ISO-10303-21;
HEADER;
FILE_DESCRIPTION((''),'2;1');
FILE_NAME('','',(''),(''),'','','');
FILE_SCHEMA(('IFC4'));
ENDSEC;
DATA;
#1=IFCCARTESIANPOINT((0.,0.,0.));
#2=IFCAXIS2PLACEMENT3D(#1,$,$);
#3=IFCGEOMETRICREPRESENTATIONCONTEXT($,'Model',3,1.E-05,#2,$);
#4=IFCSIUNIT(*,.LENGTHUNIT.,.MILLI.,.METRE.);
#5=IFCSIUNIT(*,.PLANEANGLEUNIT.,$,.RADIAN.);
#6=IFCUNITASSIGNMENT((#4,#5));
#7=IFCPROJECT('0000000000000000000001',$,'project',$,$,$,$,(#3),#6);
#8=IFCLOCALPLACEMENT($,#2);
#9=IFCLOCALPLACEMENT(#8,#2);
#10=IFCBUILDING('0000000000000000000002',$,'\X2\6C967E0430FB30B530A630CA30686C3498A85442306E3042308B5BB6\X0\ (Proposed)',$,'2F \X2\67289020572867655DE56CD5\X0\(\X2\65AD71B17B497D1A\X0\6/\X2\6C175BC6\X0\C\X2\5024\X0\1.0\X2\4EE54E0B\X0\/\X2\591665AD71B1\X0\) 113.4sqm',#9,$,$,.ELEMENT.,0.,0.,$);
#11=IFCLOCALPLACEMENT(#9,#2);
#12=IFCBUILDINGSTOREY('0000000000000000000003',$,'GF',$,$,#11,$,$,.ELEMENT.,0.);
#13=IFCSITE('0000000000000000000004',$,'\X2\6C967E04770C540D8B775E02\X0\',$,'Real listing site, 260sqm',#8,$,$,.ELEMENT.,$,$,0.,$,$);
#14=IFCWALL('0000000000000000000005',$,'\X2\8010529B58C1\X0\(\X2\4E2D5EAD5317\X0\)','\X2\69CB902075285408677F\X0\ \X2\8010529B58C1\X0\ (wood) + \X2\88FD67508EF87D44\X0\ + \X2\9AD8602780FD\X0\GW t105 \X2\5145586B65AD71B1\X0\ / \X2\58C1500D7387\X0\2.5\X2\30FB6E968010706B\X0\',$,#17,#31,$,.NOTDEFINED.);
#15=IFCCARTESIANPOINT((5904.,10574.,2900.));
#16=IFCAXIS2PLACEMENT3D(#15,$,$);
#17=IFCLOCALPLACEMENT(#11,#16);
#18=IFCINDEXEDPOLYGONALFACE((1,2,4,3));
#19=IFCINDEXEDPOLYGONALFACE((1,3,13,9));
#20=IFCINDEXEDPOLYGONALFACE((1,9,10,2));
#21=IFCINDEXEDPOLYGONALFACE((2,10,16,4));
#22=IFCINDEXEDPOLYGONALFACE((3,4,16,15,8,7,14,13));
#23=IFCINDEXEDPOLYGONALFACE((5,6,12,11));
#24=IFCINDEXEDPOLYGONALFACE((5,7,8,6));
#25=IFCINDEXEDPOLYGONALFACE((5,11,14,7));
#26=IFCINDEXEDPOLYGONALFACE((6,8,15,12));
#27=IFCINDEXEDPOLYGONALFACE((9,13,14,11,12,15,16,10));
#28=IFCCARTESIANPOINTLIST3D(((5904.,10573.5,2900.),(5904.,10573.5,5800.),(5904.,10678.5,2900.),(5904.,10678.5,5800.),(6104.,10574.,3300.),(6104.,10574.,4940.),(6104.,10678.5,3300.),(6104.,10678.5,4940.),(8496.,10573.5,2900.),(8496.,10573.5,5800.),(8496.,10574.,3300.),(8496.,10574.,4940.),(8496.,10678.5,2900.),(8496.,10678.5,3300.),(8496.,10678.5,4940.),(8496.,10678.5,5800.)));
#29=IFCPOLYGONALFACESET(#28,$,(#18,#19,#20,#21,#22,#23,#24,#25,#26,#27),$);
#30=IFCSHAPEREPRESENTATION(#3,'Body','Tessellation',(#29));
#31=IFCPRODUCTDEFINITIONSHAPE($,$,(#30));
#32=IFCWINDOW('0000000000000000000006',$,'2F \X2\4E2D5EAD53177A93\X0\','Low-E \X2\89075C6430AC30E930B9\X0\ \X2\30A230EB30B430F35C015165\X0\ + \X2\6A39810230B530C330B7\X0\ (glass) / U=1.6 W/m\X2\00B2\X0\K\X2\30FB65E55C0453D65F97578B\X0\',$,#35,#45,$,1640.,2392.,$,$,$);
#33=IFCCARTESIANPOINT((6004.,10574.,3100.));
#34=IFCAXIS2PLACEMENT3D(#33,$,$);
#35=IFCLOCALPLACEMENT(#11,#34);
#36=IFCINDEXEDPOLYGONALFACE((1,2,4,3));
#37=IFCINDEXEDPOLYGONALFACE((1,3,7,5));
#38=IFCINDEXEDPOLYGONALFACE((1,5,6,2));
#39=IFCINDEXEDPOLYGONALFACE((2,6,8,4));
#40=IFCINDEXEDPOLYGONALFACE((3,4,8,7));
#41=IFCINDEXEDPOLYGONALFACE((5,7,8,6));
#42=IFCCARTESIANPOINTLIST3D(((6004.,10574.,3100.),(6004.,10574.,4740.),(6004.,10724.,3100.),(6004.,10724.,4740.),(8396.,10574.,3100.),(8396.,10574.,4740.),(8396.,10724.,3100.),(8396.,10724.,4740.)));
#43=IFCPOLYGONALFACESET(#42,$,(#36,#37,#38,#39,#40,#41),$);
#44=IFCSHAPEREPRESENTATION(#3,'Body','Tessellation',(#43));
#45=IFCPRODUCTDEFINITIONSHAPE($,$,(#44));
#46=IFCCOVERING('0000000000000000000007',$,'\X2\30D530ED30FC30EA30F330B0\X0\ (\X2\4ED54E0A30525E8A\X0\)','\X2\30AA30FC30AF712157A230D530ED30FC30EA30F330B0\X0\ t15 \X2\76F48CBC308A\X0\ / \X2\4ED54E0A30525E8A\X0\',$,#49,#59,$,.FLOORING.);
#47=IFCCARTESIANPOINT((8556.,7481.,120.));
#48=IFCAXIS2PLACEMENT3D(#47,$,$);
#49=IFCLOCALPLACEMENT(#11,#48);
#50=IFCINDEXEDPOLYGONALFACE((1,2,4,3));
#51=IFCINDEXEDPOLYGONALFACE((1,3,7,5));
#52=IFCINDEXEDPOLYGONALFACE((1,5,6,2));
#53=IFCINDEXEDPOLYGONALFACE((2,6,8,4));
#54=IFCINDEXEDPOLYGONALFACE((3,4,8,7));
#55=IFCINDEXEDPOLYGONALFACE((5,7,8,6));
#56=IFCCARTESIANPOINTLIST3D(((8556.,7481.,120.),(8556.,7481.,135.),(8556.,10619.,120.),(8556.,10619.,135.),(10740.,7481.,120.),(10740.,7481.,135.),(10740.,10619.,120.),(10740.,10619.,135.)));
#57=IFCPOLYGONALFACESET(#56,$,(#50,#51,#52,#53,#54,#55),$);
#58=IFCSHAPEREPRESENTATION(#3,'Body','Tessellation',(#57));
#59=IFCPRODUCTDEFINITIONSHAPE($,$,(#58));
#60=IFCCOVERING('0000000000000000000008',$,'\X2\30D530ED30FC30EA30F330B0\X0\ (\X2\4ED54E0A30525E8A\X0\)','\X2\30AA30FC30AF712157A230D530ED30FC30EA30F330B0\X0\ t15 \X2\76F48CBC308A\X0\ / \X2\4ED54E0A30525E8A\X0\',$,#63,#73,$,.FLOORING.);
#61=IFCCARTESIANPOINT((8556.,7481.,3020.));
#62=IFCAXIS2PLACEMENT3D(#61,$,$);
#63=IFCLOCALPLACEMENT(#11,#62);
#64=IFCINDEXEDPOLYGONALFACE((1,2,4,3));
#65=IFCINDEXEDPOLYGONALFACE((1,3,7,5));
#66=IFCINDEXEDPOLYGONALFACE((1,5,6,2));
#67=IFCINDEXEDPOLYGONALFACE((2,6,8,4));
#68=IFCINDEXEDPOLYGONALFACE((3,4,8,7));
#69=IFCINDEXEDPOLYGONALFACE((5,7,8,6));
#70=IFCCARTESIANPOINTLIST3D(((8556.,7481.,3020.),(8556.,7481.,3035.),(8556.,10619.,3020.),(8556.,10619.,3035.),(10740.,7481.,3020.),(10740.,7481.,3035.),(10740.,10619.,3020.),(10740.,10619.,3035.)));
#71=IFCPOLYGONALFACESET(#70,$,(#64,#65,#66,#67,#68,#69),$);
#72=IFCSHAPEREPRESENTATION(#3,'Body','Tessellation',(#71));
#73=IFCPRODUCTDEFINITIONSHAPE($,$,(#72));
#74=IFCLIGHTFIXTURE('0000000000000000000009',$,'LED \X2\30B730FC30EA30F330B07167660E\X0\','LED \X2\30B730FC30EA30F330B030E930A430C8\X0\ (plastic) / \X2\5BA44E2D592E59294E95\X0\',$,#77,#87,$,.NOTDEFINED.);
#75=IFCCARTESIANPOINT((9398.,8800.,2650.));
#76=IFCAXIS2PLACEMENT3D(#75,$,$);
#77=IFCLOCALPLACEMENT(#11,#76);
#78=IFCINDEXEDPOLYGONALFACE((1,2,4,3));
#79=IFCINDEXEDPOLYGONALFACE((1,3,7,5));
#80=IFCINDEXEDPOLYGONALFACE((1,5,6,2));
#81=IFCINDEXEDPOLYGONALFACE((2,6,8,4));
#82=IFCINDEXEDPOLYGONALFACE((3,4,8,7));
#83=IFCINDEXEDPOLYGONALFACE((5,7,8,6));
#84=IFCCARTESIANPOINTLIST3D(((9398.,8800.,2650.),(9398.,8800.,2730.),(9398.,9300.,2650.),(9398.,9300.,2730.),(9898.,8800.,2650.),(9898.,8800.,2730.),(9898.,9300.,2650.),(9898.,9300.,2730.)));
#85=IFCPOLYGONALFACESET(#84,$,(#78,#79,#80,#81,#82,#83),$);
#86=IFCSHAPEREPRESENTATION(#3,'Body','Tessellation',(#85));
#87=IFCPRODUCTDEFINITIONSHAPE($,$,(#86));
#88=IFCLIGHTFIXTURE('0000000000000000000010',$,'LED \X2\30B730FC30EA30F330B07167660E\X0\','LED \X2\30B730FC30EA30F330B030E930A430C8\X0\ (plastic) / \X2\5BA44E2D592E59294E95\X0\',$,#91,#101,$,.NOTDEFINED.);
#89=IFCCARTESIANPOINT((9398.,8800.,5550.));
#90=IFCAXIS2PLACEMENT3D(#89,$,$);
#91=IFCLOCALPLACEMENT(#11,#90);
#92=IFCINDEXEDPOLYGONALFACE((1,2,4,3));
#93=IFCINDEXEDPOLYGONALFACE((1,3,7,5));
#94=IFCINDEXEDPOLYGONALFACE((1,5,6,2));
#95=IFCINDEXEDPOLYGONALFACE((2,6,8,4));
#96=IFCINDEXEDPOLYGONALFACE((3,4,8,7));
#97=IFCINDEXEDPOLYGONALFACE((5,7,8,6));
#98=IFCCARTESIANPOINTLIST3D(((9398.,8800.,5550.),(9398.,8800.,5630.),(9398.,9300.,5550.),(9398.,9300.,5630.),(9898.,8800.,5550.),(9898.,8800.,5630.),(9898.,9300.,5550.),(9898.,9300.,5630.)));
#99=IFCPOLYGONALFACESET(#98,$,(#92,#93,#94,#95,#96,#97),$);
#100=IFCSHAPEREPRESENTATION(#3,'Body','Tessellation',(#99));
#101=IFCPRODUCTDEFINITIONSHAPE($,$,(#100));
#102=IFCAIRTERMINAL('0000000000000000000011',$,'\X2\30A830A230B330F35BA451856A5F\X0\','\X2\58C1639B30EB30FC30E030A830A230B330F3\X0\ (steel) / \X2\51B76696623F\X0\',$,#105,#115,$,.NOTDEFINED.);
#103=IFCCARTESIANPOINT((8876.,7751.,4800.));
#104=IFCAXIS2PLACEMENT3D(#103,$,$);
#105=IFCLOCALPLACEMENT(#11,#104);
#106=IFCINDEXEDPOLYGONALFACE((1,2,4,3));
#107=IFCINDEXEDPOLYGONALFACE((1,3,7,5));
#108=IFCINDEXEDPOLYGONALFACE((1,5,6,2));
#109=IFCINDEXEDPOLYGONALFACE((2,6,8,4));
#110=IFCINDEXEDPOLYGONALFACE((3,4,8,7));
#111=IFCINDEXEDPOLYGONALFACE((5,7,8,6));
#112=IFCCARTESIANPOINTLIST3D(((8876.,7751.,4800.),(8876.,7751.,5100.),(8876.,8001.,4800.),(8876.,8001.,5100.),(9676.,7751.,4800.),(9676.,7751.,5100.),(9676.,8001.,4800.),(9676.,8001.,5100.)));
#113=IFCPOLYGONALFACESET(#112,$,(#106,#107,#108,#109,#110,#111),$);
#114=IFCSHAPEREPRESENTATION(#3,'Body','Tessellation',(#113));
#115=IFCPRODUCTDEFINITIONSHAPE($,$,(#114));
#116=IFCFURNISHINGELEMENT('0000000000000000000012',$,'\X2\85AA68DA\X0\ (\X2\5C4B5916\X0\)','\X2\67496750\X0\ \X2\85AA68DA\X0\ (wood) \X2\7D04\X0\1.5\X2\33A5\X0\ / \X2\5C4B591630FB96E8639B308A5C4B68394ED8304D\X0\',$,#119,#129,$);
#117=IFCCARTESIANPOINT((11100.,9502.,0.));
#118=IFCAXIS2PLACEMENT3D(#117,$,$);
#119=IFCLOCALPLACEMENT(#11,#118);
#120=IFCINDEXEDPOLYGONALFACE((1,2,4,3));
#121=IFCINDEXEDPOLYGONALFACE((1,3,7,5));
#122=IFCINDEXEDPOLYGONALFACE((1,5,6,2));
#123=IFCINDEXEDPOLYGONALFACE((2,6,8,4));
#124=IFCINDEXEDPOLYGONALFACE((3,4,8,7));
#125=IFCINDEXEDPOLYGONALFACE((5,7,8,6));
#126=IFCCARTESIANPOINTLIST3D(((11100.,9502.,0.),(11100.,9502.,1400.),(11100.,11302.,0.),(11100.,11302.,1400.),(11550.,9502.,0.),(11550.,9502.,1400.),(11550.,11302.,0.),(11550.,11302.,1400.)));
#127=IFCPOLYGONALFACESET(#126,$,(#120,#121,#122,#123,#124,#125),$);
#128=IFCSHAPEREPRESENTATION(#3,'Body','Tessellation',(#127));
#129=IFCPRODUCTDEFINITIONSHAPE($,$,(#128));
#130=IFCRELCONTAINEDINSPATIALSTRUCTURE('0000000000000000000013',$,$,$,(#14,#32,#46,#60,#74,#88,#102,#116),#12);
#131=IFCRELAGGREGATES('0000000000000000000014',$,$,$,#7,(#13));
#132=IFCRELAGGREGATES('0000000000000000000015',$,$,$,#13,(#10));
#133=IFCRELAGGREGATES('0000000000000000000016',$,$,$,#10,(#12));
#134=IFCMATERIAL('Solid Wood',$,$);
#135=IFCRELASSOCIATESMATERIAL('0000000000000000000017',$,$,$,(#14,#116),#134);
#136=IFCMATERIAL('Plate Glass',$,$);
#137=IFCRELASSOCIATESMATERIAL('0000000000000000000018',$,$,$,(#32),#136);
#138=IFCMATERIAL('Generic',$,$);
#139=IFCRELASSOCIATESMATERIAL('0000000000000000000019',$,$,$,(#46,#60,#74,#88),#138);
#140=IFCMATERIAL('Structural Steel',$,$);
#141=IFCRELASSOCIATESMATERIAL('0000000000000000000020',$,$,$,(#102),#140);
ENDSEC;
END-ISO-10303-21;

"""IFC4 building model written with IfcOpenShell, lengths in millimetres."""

from ifc_helpers import new_model, si_unit, frame, frame_2d, origin, place, context, project, spatial, rectangle, extrude, material, element, fill, save


model = new_model("IFC4")

# Units and contexts
model_context = context("Model", 3, precision=1e-05, world=origin())
ifc_project = project(units=[si_unit("LENGTHUNIT", "METRE", prefix="MILLI"), si_unit("PLANEANGLEUNIT", "RADIAN")], contexts=[model_context])

# Site, building, storey
site_placement = place(None, origin())
site = spatial("IfcSite", under=ifc_project, at=site_placement, Name="沖縄県名護市", ObjectType="Real listing site, 260sqm", CompositionType="ELEMENT", RefElevation=0.0)
building_placement = place(site_placement, origin())
building = spatial("IfcBuilding", under=site, at=building_placement, Name="沖縄・サウナと水風呂のある家 (Proposed)", ObjectType="2F 木造在来工法(断熱等級6/気密C値1.0以下/外断熱) 113.4sqm", CompositionType="ELEMENT", ElevationOfRefHeight=0.0, ElevationOfTerrain=0.0)
storey_placement = place(building_placement, origin())
storey = spatial("IfcBuildingStorey", under=building, at=storey_placement, Name="GF", CompositionType="ELEMENT", Elevation=0.0)

# Shared definitions
ifc_material_1 = material(Name="Solid Wood")

# Wall, opening, window
ifc_material_2 = material(Name="Plate Glass")
wall_1_placement = place(storey_placement, frame((5904.0, 10574.0, 2900.0)))
wall_1 = element("IfcWall", 1, at=wall_1_placement, inside=storey, material=ifc_material_1, Name="耐力壁(中庭北)", Description="構造用合板 耐力壁 (wood) + 製材軸組 + 高性能GW t105 充填断熱 / 壁倍率2.5・準耐火", PredefinedType="NOTDEFINED", context=model_context, shape_type="SweptSolid", body=[
    extrude(rectangle(XDim=2592.0, YDim=105.0, at=frame_2d((1296.0, 52.0))), frame((5904.0, 10574.0, 2900.0)), (0.0, 0.0, 1.0), 2900.0),
])
opening_1_placement = place(storey_placement, frame((6004.0, 10574.0, 3100.0)))
opening_1 = element("IfcOpeningElement", 2, at=opening_1_placement, cuts=wall_1, PredefinedType="NOTDEFINED", context=model_context, shape_type="SweptSolid", body=[
    extrude(rectangle(XDim=2392.0, YDim=150.0, at=frame_2d((1196.0, 75.0))), frame((6004.0, 10574.0, 3100.0)), (0.0, 0.0, 1.0), 1640.0),
])
window_1_placement = place(storey_placement, frame((6004.0, 10574.0, 3100.0)))
window_1 = element("IfcWindow", 3, at=window_1_placement, inside=storey, material=ifc_material_2, Name="2F 中庭北窓", Description="Low-E 複層ガラス アルゴン封入 + 樹脂サッシ (glass) / U=1.6 W/m²K・日射取得型", OverallHeight=1640.0, OverallWidth=2392.0, context=model_context, shape_type="SweptSolid", body=[
    extrude(rectangle(XDim=2392.0, YDim=150.0, at=frame_2d((1196.0, 75.0))), frame((6004.0, 10574.0, 3100.0)), (0.0, 0.0, 1.0), 1640.0),
])
fill(opening_1, window_1)

# Coverings
ifc_material_3 = material(Name="Generic")
covering_1_placement = place(storey_placement, frame((8556.0, 7481.0, 120.0)))
element("IfcCovering", 4, at=covering_1_placement, inside=storey, material=ifc_material_3, Name="フローリング (仕上げ床)", Description="オーク無垢フローリング t15 直貼り / 仕上げ床", PredefinedType="FLOORING", context=model_context, shape_type="SweptSolid", body=[
    extrude(rectangle(XDim=2184.0, YDim=3138.0, at=frame_2d((1092.0, 1569.0))), frame((8556.0, 7481.0, 120.0)), (0.0, 0.0, 1.0), 15.0),
])
covering_2_placement = place(storey_placement, frame((8556.0, 7481.0, 3020.0)))
element("IfcCovering", 5, at=covering_2_placement, inside=storey, material=ifc_material_3, Name="フローリング (仕上げ床)", Description="オーク無垢フローリング t15 直貼り / 仕上げ床", PredefinedType="FLOORING", context=model_context, shape_type="SweptSolid", body=[
    extrude(rectangle(XDim=2184.0, YDim=3138.0, at=frame_2d((1092.0, 1569.0))), frame((8556.0, 7481.0, 3020.0)), (0.0, 0.0, 1.0), 15.0),
])

# Light fixtures
light_fixture_1_placement = place(storey_placement, frame((9398.0, 8800.0, 2650.0)))
element("IfcLightFixture", 6, at=light_fixture_1_placement, inside=storey, material=ifc_material_3, Name="LED シーリング照明", Description="LED シーリングライト (plastic) / 室中央天井", PredefinedType="NOTDEFINED", context=model_context, shape_type="SweptSolid", body=[
    extrude(rectangle(XDim=500.0, YDim=500.0, at=frame_2d((250.0, 250.0))), frame((9398.0, 8800.0, 2650.0)), (0.0, 0.0, 1.0), 80.0),
])
light_fixture_2_placement = place(storey_placement, frame((9398.0, 8800.0, 5550.0)))
element("IfcLightFixture", 7, at=light_fixture_2_placement, inside=storey, material=ifc_material_3, Name="LED シーリング照明", Description="LED シーリングライト (plastic) / 室中央天井", PredefinedType="NOTDEFINED", context=model_context, shape_type="SweptSolid", body=[
    extrude(rectangle(XDim=500.0, YDim=500.0, at=frame_2d((250.0, 250.0))), frame((9398.0, 8800.0, 5550.0)), (0.0, 0.0, 1.0), 80.0),
])

# Air terminal
ifc_material_4 = material(Name="Structural Steel")
air_terminal_placement = place(storey_placement, frame((8876.0, 7751.0, 4800.0)))
element("IfcAirTerminal", 8, at=air_terminal_placement, inside=storey, material=ifc_material_4, Name="エアコン室内機", Description="壁掛ルームエアコン (steel) / 冷暖房", PredefinedType="NOTDEFINED", context=model_context, shape_type="SweptSolid", body=[
    extrude(rectangle(XDim=800.0, YDim=250.0, at=frame_2d((400.0, 125.0))), frame((8876.0, 7751.0, 4800.0)), (0.0, 0.0, 1.0), 300.0),
])

# Furnishing element
furnishing_placement = place(storey_placement, frame((11100.0, 9502.0, 0.0)))
element("IfcFurnishingElement", 9, at=furnishing_placement, inside=storey, material=ifc_material_1, Name="薪棚 (屋外)", Description="杉材 薪棚 (wood) 約1.5㎥ / 屋外・雨掛り屋根付き", context=model_context, shape_type="SweptSolid", body=[
    extrude(rectangle(XDim=450.0, YDim=1800.0, at=frame_2d((225.0, 900.0))), frame((11100.0, 9502.0, 0.0)), (0.0, 0.0, 1.0), 1400.0),
])

save(model, "model.ifc")
